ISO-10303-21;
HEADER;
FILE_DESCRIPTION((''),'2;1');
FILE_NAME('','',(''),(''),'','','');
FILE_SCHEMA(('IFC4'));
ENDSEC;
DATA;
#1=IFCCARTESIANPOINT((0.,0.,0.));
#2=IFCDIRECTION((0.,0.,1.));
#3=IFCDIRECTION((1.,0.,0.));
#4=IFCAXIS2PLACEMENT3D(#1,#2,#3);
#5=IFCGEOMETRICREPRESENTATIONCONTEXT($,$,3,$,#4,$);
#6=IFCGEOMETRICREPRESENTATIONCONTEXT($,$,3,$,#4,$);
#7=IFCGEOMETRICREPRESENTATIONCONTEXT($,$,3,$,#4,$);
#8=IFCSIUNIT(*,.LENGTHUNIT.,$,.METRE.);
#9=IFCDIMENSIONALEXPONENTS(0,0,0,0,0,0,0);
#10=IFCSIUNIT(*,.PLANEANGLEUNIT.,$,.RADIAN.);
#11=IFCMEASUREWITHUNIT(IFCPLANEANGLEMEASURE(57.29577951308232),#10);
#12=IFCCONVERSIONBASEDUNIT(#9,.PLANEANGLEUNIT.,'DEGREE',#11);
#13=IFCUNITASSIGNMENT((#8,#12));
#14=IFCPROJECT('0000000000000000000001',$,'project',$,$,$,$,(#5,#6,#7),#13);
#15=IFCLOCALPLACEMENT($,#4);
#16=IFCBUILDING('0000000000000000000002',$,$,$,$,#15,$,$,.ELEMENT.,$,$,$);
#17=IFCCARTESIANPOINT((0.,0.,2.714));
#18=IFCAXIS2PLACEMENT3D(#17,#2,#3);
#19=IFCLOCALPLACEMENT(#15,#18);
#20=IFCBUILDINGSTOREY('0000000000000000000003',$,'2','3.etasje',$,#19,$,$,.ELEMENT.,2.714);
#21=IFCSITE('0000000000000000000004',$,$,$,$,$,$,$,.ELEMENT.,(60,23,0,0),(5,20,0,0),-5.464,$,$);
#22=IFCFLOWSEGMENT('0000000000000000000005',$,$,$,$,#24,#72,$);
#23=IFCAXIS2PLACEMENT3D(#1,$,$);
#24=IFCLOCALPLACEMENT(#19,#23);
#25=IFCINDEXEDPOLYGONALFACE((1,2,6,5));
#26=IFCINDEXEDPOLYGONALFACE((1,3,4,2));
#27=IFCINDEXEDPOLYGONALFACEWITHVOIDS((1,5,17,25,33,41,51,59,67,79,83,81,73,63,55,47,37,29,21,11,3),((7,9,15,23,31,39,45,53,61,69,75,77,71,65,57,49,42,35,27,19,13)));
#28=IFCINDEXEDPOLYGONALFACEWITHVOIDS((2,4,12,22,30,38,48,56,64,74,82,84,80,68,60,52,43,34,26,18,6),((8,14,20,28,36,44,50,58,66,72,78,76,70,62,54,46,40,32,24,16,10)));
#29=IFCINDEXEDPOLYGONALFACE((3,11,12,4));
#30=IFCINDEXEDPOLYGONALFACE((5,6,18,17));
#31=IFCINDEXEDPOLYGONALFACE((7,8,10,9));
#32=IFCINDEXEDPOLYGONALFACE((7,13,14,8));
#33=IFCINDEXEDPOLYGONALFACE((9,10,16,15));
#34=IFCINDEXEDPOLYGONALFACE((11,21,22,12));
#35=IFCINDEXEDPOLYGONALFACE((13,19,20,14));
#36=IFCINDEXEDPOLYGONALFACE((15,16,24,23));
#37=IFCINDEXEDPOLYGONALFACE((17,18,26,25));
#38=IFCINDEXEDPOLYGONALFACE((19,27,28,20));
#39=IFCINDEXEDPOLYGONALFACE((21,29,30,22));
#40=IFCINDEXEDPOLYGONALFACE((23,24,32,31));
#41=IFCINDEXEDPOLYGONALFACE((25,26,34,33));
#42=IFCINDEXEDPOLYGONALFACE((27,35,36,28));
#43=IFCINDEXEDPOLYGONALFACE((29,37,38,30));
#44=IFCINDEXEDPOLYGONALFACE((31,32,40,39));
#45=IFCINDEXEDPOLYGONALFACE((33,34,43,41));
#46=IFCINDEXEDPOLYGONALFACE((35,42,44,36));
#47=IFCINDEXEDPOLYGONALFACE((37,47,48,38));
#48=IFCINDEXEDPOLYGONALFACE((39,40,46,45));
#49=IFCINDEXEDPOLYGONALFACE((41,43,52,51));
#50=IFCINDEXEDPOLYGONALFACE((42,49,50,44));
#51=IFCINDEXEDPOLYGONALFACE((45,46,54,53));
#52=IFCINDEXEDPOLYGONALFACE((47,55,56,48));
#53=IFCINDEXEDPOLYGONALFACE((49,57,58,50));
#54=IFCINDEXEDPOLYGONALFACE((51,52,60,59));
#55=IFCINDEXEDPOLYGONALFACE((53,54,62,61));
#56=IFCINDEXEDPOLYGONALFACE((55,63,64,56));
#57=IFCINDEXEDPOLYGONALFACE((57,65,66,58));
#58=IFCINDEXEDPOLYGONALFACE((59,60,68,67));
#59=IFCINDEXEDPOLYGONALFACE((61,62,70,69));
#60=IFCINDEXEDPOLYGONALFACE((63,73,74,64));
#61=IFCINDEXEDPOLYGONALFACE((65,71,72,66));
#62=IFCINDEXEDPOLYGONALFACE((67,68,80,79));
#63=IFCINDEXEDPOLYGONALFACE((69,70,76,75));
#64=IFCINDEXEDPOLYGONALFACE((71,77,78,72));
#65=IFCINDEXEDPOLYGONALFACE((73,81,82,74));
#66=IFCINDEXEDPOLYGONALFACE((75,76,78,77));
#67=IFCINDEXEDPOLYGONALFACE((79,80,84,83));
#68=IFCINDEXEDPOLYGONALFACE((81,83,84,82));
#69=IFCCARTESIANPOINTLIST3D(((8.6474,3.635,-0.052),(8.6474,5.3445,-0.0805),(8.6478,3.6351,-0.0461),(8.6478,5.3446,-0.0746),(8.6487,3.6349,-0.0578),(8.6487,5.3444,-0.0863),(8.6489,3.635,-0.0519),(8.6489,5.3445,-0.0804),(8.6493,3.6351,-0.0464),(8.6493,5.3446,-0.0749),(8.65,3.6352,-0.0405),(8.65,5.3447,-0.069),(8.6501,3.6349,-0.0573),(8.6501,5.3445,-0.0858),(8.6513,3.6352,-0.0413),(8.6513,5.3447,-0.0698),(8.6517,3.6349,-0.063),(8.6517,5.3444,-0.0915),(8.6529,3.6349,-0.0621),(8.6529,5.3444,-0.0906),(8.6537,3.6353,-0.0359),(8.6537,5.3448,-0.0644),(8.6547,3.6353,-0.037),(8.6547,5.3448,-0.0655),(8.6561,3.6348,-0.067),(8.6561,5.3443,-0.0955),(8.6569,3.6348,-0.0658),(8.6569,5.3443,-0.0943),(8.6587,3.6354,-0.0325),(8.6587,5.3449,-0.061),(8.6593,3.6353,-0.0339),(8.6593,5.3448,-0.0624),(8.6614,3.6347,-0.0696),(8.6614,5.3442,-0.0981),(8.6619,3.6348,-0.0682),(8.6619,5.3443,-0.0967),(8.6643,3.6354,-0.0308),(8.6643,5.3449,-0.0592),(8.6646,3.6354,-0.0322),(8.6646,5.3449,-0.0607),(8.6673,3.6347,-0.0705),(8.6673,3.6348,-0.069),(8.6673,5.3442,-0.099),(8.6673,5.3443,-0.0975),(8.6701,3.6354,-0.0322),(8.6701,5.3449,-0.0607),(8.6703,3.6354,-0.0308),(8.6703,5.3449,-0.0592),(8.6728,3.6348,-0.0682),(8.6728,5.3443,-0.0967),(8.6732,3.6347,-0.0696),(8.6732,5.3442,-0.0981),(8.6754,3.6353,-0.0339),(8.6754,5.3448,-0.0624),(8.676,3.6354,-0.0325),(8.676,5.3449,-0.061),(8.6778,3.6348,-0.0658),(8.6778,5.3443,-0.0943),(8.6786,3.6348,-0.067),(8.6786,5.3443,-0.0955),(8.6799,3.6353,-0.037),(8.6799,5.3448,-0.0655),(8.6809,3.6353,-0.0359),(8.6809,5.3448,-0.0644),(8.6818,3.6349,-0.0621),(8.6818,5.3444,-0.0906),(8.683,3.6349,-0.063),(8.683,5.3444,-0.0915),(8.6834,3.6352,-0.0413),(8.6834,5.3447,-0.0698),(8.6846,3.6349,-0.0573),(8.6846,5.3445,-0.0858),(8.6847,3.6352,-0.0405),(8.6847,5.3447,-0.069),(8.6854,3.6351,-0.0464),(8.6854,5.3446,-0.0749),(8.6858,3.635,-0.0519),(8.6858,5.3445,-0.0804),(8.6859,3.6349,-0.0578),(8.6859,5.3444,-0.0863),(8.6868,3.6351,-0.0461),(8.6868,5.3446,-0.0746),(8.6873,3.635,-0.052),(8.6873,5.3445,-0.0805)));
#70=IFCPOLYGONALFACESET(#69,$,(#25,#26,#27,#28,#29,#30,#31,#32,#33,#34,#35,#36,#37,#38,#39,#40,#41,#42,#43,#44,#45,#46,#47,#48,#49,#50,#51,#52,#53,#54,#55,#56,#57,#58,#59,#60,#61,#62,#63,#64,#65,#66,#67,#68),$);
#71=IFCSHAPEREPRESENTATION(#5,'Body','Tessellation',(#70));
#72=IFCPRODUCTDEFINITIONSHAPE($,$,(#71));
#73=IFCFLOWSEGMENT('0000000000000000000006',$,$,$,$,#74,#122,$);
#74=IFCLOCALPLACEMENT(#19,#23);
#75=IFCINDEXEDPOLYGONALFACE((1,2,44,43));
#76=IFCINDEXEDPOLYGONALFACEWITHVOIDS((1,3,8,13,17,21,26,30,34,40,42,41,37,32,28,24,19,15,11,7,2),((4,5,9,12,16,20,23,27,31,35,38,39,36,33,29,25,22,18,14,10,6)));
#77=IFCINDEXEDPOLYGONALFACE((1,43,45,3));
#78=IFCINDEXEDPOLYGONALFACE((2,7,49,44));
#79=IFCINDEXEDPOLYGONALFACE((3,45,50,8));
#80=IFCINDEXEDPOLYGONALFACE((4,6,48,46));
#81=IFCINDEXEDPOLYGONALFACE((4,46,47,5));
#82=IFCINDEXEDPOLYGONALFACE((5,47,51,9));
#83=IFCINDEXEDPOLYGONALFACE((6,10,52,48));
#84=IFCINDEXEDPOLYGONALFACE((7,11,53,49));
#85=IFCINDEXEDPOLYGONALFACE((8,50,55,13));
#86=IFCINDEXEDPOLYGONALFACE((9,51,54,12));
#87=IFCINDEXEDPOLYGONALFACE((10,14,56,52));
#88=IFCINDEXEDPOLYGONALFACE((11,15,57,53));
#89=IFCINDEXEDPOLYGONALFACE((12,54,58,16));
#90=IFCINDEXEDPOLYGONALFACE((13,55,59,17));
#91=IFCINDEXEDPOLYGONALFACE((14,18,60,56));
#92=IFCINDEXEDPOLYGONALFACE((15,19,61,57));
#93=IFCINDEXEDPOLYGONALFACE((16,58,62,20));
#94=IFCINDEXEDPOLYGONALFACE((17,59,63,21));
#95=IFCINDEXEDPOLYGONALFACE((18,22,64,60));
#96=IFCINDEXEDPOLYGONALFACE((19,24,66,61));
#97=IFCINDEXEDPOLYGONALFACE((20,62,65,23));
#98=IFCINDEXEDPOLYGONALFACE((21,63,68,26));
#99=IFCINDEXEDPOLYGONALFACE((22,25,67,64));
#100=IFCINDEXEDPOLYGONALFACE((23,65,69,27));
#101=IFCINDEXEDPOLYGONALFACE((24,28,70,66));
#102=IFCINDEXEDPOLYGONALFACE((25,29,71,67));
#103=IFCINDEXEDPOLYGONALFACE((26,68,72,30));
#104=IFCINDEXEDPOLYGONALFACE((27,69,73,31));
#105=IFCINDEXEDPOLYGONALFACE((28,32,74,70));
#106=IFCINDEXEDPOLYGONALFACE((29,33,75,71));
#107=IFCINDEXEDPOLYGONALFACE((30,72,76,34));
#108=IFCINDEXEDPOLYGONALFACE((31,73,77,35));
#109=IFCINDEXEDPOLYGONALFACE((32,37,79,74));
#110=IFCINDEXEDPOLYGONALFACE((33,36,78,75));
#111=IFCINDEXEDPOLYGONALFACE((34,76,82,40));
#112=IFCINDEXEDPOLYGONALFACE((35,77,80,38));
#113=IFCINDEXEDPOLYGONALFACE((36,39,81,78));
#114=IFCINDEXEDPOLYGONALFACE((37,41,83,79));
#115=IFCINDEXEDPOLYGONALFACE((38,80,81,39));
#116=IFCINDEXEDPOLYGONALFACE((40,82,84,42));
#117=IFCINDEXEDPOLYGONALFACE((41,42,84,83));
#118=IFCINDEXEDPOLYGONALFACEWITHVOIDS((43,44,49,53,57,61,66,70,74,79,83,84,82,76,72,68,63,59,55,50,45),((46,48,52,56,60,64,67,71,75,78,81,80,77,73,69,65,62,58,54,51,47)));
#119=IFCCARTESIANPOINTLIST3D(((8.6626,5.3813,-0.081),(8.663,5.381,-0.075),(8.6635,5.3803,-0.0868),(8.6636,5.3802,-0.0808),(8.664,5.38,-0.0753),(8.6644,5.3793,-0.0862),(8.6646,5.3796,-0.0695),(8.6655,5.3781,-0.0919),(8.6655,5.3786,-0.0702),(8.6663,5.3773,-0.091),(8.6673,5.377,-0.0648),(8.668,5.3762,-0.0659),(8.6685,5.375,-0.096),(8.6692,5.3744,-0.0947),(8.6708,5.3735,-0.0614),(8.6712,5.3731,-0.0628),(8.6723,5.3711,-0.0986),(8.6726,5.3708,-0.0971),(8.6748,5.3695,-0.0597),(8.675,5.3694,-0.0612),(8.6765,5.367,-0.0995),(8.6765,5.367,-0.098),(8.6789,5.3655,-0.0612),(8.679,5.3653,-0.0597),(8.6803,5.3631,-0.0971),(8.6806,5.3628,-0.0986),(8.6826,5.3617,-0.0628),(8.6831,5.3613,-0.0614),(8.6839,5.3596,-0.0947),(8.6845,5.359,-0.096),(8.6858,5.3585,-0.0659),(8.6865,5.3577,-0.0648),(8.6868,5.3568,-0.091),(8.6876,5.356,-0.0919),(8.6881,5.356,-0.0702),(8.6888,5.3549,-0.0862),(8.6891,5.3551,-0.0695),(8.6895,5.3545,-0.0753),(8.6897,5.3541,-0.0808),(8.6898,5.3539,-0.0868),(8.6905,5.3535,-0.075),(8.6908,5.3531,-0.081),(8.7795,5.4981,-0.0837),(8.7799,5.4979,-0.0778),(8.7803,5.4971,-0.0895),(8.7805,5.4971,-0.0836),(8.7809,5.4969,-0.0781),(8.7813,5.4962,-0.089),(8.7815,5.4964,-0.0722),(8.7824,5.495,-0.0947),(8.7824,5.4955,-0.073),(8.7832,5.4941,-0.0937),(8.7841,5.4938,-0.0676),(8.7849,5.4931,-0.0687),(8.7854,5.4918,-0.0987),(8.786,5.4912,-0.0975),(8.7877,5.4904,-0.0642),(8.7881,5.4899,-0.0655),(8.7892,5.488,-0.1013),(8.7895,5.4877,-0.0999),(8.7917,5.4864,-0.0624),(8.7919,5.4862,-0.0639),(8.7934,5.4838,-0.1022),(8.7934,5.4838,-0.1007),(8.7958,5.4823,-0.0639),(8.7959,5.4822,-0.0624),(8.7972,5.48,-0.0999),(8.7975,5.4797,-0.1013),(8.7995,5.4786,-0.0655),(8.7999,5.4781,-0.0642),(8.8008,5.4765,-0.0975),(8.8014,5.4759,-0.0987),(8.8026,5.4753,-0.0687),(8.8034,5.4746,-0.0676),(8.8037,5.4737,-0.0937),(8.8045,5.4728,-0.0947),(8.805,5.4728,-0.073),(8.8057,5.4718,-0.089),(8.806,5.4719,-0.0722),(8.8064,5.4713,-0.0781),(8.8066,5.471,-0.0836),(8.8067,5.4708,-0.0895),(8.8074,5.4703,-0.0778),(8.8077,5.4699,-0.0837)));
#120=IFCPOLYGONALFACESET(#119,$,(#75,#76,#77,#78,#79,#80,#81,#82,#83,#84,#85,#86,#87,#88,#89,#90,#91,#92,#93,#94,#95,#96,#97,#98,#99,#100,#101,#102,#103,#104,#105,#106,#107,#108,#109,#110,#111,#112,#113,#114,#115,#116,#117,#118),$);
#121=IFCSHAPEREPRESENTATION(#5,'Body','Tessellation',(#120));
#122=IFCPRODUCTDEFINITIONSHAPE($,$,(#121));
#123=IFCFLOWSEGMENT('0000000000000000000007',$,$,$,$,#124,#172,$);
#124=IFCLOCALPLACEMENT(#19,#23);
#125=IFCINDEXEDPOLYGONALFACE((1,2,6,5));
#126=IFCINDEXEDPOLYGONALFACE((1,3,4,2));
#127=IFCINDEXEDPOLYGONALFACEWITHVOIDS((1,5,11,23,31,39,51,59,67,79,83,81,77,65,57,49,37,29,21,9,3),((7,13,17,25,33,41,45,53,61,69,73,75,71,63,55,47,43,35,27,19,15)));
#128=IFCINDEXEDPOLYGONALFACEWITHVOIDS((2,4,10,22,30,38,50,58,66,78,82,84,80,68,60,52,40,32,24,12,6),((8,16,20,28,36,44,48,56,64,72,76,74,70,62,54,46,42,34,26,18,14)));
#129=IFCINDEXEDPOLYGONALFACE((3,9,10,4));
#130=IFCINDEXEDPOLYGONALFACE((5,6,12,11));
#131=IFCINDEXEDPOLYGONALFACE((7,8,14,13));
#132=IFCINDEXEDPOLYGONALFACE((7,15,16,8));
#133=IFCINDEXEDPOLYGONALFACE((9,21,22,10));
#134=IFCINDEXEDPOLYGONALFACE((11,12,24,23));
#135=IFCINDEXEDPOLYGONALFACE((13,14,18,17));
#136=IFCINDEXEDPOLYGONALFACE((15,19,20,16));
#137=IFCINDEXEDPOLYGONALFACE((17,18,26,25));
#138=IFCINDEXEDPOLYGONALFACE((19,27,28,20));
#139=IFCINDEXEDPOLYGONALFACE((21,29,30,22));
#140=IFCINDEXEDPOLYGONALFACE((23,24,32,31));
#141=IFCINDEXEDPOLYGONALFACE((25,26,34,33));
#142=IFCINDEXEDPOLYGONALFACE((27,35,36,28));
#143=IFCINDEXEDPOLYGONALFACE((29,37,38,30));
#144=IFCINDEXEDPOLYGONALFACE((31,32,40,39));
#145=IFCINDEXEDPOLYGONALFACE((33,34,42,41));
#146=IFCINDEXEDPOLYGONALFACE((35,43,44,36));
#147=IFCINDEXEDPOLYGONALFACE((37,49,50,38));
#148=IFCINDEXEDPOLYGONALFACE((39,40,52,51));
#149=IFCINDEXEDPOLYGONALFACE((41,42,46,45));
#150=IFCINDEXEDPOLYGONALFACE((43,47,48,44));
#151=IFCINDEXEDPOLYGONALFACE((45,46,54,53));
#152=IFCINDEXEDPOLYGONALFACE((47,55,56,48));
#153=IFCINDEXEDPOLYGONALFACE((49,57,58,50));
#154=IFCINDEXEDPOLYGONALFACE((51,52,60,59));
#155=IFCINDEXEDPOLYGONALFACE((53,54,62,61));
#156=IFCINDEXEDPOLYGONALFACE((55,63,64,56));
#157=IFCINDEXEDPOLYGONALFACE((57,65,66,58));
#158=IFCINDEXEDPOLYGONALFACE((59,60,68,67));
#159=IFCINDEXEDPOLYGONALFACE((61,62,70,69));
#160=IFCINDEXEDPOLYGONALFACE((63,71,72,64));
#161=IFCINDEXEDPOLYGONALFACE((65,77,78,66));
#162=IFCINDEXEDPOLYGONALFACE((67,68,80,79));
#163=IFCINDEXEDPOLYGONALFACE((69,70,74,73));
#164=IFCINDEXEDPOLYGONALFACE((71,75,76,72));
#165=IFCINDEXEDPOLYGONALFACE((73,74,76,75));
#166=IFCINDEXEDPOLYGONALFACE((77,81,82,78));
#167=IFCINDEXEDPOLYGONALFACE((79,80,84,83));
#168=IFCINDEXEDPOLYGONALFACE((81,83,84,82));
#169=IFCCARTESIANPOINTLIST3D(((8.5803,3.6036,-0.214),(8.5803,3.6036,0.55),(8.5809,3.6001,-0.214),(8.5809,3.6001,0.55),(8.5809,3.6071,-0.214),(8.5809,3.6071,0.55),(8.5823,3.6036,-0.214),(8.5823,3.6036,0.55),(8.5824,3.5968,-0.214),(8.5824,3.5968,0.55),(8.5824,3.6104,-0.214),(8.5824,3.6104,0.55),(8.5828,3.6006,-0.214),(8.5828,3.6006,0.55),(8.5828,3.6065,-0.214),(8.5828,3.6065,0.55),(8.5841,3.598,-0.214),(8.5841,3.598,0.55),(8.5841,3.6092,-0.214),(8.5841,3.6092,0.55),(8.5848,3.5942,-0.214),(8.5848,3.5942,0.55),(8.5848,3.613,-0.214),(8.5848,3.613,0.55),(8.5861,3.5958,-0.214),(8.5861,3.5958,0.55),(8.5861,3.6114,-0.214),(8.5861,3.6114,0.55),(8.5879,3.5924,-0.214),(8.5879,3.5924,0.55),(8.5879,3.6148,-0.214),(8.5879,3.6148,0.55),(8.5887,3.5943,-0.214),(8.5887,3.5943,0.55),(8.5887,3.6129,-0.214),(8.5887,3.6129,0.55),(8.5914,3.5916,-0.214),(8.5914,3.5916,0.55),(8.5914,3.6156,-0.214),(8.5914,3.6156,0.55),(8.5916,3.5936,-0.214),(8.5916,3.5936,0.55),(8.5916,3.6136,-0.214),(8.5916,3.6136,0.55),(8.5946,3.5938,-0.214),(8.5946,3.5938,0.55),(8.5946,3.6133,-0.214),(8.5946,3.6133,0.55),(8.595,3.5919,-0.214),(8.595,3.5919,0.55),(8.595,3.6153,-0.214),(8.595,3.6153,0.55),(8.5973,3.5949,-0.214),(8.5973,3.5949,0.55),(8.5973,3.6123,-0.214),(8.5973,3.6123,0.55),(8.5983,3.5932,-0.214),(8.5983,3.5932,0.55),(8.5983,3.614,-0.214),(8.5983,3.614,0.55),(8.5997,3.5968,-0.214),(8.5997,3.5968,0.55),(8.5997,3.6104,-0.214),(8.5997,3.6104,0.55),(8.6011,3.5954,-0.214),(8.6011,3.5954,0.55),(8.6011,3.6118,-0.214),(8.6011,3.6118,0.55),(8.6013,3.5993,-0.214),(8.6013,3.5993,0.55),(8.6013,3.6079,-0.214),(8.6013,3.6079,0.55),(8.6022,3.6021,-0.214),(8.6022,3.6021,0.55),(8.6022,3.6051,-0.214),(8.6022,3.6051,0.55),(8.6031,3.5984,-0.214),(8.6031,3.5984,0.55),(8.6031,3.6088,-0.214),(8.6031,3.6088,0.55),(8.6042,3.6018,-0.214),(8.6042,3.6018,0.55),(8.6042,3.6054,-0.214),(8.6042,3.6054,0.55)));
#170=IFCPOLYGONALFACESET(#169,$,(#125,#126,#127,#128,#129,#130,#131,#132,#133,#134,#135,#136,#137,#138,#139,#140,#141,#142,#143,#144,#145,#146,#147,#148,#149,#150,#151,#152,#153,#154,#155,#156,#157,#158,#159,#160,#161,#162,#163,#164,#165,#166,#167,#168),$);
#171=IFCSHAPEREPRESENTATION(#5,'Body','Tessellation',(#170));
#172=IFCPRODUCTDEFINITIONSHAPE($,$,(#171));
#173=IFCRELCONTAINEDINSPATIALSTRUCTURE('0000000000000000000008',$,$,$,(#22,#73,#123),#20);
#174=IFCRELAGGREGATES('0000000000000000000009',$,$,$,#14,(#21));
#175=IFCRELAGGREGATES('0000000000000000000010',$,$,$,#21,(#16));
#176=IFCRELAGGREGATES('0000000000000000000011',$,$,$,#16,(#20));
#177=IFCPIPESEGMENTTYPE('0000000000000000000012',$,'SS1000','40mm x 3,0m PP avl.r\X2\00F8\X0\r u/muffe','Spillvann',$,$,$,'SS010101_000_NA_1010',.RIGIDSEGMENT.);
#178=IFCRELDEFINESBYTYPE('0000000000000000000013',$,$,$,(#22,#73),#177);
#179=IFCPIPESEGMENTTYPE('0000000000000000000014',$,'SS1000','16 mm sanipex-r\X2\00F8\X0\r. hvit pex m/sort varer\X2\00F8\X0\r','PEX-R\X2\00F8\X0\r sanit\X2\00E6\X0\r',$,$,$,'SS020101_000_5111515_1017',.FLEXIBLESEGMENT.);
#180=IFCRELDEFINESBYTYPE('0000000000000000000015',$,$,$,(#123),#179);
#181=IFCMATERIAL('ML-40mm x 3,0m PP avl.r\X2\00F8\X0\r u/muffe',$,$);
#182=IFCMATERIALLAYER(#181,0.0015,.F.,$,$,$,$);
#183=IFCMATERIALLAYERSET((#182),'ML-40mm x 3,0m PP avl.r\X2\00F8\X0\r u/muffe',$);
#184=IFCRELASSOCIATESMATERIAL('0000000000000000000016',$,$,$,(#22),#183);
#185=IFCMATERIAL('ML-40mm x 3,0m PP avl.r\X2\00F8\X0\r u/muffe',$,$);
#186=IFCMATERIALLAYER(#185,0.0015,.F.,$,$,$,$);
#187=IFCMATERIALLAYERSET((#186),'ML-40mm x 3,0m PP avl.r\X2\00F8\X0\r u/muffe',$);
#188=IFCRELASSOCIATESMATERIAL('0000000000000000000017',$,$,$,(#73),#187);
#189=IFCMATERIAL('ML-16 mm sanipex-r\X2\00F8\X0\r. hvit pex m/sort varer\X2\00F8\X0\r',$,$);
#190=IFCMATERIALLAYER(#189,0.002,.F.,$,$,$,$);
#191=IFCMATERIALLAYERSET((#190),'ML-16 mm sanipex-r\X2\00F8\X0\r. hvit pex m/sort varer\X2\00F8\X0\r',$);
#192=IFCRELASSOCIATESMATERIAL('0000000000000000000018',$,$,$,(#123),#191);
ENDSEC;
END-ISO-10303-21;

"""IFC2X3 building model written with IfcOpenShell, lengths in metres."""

from ifc_helpers import new_model, entity, si_unit, converted_unit, frame, origin_with_axes, origin_2d_with_axis, place, context, project, spatial, hollow_circle, extrude, material, layer, layer_set, layer_usage, type_object, element, save


model = new_model("IFC2X3")

# Units and contexts
context_of_model_1 = context(None, 3, world=origin_with_axes())
context_of_model_2 = context(None, 3, world=origin_with_axes())
context_of_model_3 = context(None, 3, world=origin_with_axes())
ifc_project = project(units=[si_unit("LENGTHUNIT", "METRE"), converted_unit("PLANEANGLEUNIT", "DEGREE", entity("IfcPlaneAngleMeasure", 57.29577951308232), si_unit("PLANEANGLEUNIT", "RADIAN"), dimensions=[0, 0, 0, 0, 0, 0, 0])], contexts=[context_of_model_1, context_of_model_2, context_of_model_3])

# Site, building, storey
site = spatial("IfcSite", under=ifc_project, CompositionType="ELEMENT", RefLatitude=(60, 23, 0, 0), RefLongitude=(5, 20, 0, 0), RefElevation=-5.464)
building_placement = place(None, origin_with_axes())
building = spatial("IfcBuilding", under=site, at=building_placement, CompositionType="ELEMENT")
storey_placement = place(building_placement, frame((0.0, 0.0, 2.714), z_axis=(0.0, 0.0, 1.0), x_axis=(1.0, 0.0, 0.0)))
storey = spatial("IfcBuildingStorey", under=building, at=storey_placement, Name="2", Description="3.etasje", CompositionType="ELEMENT", Elevation=2.714)

# Flow segments
pipe_segment_type_1 = type_object("IfcPipeSegmentType", Name="SS1000", Description="40mm x 3,0m PP avl.rør u/muffe", ApplicableOccurrence="Spillvann", ElementType="SS010101_000_NA_1010", PredefinedType="RIGIDSEGMENT")
ifc_material_1 = material(Name="ML-40mm x 3,0m PP avl.rør u/muffe")
ifc_layer_1 = layer(ifc_material_1, 0.0015, ventilated=False)
ifc_layer_set_1 = layer_set([ifc_layer_1], Name="ML-40mm x 3,0m PP avl.rør u/muffe")
ifc_layer_usage_1 = layer_usage(ifc_layer_set_1, "AXIS2", "POSITIVE", 0.0)
flow_segment_1_placement = place(storey_placement, frame((8.6673, 3.6351, -0.0505), z_axis=(0.0, 0.999861, -0.016665), x_axis=(0.0, -0.016665, -0.999861)))
element("IfcFlowSegment", 1, at=flow_segment_1_placement, inside=storey, type_object=pipe_segment_type_1, material=ifc_layer_usage_1, context=context_of_model_1, shape_type="SweptSolid", body=[
    extrude(hollow_circle(Radius=0.02, WallThickness=0.0015, at=origin_2d_with_axis()), origin_with_axes(), (0.0, 0.0, 1.0), 1.7097),
])
ifc_material_2 = material(Name="ML-40mm x 3,0m PP avl.rør u/muffe")
ifc_layer_2 = layer(ifc_material_2, 0.0015, ventilated=False)
ifc_layer_set_2 = layer_set([ifc_layer_2], Name="ML-40mm x 3,0m PP avl.rør u/muffe")
ifc_layer_usage_2 = layer_usage(ifc_layer_set_2, "AXIS2", "POSITIVE", 0.0)
flow_segment_2_placement = place(storey_placement, frame((8.6767, 5.3672, -0.0795), z_axis=(0.70709, 0.706927, -0.016665), x_axis=(-0.011785, -0.011782, -0.999861)))
element("IfcFlowSegment", 2, at=flow_segment_2_placement, inside=storey, type_object=pipe_segment_type_1, material=ifc_layer_usage_2, context=context_of_model_1, shape_type="SweptSolid", body=[
    extrude(hollow_circle(Radius=0.02, WallThickness=0.0015, at=origin_2d_with_axis()), origin_with_axes(), (0.0, 0.0, 1.0), 0.1653),
])
ifc_material_3 = material(Name="ML-16 mm sanipex-rør. hvit pex m/sort varerør")
ifc_layer_3 = layer(ifc_material_3, 0.002, ventilated=False)
ifc_layer_set_3 = layer_set([ifc_layer_3], Name="ML-16 mm sanipex-rør. hvit pex m/sort varerør")
ifc_layer_usage_3 = layer_usage(ifc_layer_set_3, "AXIS2", "POSITIVE", 0.0)
pipe_segment_type_2 = type_object("IfcPipeSegmentType", Name="SS1000", Description="16 mm sanipex-rør. hvit pex m/sort varerør", ApplicableOccurrence="PEX-Rør sanitær", ElementType="SS020101_000_5111515_1017", PredefinedType="FLEXIBLESEGMENT")
flow_segment_3_placement = place(storey_placement, frame((8.5923, 3.6036, 0.55), z_axis=(0.0, 0.0, -1.0), x_axis=(-1.0, 0.0, 0.0)))
element("IfcFlowSegment", 3, at=flow_segment_3_placement, inside=storey, type_object=pipe_segment_type_2, material=ifc_layer_usage_3, context=context_of_model_1, shape_type="SweptSolid", body=[
    extrude(hollow_circle(Radius=0.012, WallThickness=0.002, at=origin_2d_with_axis()), origin_with_axes(), (0.0, 0.0, 1.0), 0.764),
])

save(model, "model.ifc")
